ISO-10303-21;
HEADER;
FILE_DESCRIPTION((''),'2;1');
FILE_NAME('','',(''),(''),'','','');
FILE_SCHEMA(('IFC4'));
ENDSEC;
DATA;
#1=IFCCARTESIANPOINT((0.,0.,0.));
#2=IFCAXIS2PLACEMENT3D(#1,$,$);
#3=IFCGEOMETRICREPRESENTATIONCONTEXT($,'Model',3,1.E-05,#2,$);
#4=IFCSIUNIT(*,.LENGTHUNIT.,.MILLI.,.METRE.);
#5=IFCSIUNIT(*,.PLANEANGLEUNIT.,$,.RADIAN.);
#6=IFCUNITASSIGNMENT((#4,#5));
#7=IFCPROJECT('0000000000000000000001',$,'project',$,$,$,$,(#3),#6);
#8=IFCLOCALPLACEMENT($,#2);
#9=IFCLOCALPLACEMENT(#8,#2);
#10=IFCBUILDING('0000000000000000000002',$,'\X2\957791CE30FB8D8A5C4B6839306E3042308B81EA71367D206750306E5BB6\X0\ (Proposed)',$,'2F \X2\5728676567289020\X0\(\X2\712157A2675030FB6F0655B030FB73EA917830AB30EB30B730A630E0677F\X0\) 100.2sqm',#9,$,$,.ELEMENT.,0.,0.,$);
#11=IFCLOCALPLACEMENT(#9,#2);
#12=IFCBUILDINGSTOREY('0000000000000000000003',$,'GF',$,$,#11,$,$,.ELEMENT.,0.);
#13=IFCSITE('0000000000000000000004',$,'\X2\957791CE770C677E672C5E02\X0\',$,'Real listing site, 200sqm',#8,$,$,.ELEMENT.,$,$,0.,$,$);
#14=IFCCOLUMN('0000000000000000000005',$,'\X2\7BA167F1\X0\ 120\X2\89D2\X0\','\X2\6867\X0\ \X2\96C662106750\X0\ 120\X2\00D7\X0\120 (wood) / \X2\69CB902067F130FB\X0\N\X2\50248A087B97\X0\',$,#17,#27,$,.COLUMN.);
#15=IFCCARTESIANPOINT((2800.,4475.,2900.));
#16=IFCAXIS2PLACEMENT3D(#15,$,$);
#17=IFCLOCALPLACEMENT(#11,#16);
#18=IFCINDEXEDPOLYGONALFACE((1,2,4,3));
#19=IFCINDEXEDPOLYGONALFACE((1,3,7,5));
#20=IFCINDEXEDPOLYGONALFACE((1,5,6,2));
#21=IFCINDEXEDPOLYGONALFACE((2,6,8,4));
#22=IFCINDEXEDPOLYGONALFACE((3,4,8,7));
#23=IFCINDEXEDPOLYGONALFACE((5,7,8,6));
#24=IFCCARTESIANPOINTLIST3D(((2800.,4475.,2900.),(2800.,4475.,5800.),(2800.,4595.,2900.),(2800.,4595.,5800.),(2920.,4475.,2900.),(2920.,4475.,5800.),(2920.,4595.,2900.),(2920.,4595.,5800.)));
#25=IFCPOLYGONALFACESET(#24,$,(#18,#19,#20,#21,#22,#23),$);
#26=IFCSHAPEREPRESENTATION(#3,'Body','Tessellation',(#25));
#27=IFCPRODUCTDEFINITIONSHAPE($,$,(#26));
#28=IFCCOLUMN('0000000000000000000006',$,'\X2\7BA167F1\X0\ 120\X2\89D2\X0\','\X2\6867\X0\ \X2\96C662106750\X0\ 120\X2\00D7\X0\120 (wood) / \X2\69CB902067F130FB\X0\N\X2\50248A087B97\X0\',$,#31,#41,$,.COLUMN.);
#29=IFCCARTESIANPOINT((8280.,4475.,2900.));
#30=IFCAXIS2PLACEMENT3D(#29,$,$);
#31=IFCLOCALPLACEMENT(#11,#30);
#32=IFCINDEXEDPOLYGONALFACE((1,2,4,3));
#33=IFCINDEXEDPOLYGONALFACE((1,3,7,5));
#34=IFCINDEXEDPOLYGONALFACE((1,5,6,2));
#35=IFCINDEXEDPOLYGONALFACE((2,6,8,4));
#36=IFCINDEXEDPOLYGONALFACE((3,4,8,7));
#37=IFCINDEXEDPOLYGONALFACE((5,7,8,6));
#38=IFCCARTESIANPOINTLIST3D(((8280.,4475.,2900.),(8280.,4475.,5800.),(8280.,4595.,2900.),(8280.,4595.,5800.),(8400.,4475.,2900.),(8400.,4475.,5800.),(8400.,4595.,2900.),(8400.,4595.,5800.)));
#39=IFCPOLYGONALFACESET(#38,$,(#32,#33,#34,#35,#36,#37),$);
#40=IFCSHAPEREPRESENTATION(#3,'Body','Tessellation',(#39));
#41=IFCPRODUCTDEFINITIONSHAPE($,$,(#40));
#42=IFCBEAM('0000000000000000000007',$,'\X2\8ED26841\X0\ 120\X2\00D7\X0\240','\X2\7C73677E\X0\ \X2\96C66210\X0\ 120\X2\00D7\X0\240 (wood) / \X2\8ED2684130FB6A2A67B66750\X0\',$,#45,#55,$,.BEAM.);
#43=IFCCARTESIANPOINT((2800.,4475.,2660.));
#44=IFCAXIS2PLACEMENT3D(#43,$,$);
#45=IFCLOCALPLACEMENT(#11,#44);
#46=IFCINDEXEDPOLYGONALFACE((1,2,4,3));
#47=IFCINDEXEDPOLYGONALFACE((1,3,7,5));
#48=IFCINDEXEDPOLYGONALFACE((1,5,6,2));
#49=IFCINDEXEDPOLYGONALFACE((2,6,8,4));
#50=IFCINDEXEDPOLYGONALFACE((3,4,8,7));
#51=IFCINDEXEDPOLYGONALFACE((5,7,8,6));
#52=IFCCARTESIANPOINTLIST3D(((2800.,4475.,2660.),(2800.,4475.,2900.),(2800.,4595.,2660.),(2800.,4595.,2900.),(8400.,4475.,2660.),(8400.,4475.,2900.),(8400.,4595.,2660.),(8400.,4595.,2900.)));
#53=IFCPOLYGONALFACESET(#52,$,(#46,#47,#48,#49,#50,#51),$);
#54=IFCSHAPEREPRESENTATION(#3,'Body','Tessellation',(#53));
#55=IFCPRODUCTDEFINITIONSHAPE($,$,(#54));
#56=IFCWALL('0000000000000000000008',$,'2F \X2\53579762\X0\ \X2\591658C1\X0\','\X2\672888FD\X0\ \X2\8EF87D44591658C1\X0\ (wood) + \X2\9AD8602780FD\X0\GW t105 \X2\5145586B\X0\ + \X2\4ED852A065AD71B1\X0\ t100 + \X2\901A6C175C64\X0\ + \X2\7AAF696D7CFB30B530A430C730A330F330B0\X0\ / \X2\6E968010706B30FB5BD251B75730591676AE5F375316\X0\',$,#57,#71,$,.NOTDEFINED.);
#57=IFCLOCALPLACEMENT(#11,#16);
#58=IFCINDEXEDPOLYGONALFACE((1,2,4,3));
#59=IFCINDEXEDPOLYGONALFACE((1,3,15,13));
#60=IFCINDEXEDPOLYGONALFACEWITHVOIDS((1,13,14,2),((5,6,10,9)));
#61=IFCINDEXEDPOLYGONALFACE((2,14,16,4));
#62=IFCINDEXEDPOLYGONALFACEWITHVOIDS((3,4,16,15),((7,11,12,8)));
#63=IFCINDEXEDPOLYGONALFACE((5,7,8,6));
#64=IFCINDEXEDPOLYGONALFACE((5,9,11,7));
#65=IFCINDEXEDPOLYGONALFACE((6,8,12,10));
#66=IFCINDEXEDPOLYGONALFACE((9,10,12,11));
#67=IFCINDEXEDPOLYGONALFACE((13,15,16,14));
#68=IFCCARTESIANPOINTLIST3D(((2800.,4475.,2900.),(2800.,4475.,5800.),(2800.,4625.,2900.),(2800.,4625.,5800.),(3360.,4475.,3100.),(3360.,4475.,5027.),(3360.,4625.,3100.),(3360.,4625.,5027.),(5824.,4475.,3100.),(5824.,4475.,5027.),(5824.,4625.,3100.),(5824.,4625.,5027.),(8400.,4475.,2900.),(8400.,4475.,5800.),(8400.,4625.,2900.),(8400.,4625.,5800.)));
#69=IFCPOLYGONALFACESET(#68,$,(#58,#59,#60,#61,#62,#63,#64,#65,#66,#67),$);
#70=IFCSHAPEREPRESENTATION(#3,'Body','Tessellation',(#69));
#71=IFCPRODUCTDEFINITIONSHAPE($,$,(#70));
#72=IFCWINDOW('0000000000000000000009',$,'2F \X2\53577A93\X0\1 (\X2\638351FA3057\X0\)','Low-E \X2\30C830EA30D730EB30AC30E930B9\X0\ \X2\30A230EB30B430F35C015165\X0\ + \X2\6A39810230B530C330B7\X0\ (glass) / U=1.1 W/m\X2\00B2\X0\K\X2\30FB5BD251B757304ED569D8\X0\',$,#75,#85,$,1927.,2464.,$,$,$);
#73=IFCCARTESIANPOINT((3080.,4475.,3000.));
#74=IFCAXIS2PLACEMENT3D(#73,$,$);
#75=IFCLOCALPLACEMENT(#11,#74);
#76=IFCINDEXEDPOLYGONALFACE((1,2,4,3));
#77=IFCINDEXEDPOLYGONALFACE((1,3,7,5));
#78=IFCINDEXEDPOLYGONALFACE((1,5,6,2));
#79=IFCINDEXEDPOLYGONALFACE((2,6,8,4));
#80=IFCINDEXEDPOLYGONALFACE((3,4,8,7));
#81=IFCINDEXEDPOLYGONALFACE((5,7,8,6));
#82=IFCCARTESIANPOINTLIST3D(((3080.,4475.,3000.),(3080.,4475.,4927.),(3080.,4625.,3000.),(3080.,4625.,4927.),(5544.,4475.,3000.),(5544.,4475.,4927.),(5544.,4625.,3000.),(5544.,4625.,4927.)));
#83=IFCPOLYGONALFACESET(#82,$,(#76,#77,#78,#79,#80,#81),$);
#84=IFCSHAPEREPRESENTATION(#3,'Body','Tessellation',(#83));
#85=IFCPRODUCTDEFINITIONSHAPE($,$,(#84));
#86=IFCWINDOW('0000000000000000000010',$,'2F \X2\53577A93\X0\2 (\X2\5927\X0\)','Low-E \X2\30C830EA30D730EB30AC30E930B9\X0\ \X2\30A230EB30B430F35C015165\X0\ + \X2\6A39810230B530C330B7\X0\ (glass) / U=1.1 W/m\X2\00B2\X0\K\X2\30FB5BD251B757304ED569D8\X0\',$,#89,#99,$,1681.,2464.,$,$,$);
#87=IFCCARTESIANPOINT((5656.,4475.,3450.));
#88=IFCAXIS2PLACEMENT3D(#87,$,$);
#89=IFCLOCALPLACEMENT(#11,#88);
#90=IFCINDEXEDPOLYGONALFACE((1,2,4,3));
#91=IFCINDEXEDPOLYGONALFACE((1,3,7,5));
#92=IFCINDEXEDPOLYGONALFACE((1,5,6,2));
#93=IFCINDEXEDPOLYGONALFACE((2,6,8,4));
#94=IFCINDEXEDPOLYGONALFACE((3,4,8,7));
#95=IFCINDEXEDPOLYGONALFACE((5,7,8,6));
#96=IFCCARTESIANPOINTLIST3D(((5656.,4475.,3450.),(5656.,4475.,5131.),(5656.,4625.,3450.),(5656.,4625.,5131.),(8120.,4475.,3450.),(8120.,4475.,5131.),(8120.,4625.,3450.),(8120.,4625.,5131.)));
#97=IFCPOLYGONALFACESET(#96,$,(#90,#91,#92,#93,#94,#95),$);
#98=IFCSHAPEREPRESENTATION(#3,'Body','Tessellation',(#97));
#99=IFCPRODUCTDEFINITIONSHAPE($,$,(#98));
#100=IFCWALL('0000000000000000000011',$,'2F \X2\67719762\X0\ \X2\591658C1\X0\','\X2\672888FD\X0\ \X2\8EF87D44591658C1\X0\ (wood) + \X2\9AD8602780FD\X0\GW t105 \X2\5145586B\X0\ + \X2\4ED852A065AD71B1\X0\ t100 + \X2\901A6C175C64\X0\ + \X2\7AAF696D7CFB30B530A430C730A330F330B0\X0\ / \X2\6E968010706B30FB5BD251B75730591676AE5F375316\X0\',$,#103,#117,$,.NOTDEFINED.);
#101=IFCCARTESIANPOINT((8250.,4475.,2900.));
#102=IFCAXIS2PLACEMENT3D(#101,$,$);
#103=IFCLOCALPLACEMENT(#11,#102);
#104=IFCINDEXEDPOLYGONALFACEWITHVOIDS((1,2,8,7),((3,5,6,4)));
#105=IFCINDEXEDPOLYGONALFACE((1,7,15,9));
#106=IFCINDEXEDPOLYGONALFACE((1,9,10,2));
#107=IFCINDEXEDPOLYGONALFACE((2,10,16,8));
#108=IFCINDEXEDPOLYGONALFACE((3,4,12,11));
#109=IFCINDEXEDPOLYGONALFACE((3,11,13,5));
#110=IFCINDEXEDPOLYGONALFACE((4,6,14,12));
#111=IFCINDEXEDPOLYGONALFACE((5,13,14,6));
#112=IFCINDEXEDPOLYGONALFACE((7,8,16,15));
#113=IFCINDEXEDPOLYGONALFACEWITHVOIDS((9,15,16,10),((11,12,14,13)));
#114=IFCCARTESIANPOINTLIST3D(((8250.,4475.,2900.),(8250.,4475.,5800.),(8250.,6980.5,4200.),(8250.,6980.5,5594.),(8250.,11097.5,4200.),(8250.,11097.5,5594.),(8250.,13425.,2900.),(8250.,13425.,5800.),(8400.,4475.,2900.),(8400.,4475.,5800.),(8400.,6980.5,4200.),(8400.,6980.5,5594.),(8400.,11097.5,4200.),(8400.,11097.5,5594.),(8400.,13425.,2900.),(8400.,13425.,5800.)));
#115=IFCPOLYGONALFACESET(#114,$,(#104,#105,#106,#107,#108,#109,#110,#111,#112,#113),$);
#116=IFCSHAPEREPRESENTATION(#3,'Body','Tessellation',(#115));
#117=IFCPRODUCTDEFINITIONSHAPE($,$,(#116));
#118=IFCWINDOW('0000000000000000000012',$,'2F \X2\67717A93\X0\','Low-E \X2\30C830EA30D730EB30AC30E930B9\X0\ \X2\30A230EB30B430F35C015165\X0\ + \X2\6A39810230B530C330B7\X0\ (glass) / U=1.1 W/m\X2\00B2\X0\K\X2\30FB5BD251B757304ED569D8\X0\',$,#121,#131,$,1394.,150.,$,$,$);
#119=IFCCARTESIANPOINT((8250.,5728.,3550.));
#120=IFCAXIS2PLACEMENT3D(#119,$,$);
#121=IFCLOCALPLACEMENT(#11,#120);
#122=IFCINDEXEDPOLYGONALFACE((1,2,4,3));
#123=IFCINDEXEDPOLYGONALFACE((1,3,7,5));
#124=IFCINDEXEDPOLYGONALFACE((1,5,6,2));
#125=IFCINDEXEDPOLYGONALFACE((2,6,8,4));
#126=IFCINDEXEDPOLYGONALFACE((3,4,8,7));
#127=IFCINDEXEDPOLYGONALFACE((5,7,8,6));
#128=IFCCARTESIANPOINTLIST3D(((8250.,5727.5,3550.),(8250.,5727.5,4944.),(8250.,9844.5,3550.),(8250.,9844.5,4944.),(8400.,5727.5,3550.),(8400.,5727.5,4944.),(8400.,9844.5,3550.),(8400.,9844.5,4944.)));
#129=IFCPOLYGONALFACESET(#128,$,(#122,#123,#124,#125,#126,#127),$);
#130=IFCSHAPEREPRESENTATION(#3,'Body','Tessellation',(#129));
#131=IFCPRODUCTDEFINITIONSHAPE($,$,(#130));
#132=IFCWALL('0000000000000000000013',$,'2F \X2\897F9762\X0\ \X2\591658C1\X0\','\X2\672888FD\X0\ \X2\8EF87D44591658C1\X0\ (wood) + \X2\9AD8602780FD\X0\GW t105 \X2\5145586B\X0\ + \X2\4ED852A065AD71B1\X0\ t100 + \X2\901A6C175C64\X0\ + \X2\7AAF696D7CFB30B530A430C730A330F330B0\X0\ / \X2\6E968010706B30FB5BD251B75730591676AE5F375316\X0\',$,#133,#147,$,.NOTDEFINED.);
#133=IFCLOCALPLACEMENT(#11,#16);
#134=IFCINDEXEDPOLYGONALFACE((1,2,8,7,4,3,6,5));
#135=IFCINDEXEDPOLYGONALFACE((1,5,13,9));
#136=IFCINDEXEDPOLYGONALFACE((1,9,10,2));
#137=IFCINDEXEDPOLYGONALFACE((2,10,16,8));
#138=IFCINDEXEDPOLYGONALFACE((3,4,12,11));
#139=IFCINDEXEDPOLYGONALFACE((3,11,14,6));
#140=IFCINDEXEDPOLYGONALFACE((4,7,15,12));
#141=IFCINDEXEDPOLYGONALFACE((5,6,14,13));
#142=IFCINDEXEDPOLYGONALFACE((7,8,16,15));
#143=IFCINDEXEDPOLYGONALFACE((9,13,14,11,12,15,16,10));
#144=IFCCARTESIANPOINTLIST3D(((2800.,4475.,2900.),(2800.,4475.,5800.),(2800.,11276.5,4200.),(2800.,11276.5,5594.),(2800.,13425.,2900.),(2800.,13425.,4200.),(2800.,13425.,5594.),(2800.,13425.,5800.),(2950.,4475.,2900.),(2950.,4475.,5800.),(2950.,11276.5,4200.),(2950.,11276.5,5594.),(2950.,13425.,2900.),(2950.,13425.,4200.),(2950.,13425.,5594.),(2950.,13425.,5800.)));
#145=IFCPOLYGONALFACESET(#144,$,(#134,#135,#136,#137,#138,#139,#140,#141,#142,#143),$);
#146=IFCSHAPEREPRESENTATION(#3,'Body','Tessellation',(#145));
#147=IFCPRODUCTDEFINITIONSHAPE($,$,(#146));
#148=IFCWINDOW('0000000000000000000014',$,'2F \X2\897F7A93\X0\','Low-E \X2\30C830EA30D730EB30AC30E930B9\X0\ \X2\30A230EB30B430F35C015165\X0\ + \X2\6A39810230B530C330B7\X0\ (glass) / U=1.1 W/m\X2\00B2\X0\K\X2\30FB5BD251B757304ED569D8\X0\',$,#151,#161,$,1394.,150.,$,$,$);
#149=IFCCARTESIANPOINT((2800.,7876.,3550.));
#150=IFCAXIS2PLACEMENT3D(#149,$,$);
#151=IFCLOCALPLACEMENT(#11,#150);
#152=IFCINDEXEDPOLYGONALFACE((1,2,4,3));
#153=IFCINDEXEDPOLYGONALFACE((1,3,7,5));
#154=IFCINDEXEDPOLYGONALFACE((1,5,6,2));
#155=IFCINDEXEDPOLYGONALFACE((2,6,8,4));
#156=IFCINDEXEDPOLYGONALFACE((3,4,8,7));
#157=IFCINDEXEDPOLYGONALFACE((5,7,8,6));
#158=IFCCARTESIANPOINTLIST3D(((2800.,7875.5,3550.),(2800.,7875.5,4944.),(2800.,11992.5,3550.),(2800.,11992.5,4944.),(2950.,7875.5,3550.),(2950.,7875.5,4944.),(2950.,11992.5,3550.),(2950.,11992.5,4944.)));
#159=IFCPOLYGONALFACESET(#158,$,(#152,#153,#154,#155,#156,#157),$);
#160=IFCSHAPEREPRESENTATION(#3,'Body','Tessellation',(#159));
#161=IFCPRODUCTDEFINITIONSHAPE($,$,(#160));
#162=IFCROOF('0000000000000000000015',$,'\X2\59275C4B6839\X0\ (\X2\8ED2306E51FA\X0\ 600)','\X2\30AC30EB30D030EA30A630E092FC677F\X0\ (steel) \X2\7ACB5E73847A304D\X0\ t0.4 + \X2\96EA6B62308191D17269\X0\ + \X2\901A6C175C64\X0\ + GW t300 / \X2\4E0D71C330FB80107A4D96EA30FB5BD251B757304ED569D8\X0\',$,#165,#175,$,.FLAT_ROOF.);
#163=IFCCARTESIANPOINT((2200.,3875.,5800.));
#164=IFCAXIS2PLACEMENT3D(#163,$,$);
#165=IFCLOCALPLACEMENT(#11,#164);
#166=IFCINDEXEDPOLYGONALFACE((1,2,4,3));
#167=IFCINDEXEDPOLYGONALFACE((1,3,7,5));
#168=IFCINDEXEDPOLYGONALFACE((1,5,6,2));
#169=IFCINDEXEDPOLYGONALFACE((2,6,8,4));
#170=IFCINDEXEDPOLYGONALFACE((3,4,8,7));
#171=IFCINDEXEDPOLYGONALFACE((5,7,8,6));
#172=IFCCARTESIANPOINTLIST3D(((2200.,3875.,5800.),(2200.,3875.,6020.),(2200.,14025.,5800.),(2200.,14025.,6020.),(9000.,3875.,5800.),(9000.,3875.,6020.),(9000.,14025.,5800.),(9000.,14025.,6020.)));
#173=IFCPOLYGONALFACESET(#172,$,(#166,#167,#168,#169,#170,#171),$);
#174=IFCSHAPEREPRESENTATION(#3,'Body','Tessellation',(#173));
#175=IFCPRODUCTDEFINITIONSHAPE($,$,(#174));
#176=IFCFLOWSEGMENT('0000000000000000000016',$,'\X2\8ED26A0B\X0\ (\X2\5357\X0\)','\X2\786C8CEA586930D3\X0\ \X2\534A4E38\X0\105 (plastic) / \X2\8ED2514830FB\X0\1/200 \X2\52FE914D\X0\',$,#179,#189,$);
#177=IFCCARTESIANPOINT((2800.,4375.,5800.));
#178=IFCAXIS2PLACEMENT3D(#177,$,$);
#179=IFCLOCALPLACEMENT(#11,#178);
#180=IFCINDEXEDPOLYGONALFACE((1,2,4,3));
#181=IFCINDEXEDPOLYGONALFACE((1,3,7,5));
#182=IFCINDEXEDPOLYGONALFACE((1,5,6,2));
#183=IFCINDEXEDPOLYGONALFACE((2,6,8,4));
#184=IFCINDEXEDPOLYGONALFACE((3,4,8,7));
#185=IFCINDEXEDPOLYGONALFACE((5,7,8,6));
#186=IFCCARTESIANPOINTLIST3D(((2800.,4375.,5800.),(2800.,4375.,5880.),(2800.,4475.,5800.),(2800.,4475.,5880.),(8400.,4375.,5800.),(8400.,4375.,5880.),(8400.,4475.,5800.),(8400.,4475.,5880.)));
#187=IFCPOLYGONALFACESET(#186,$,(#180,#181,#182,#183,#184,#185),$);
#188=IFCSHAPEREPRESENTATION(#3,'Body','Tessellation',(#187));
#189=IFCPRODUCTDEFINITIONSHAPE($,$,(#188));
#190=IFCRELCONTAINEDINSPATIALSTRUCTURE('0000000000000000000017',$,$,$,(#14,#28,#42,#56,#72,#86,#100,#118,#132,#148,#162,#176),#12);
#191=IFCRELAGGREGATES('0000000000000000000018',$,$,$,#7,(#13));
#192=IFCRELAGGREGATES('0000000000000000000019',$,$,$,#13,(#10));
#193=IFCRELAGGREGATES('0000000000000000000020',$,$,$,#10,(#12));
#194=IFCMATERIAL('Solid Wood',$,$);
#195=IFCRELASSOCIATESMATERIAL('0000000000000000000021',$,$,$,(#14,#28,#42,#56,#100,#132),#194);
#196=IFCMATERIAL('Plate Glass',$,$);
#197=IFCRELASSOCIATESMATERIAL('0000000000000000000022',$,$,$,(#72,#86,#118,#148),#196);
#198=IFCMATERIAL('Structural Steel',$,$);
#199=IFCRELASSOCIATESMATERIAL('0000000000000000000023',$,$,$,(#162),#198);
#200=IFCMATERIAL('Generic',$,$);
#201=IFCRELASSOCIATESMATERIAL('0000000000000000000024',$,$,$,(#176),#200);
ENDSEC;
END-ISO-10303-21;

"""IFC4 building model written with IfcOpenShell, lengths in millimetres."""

from ifc_helpers import new_model, si_unit, frame, frame_2d, origin, place, context, project, spatial, rectangle, extrude, material, element, fill, save


model = new_model("IFC4")

# Units and contexts
model_context = context("Model", 3, precision=1e-05, world=origin())
ifc_project = project(units=[si_unit("LENGTHUNIT", "METRE", prefix="MILLI"), si_unit("PLANEANGLEUNIT", "RADIAN")], contexts=[model_context])

# Site, building, storey
site_placement = place(None, origin())
site = spatial("IfcSite", under=ifc_project, at=site_placement, Name="長野県松本市", ObjectType="Real listing site, 200sqm", CompositionType="ELEMENT", RefElevation=0.0)
building_placement = place(site_placement, origin())
building = spatial("IfcBuilding", under=site, at=building_placement, Name="長野・越屋根のある自然素材の家 (Proposed)", ObjectType="2F 在来木造(無垢材・漆喰・珪酸カルシウム板) 100.2sqm", CompositionType="ELEMENT", ElevationOfRefHeight=0.0, ElevationOfTerrain=0.0)
storey_placement = place(building_placement, origin())
storey = spatial("IfcBuildingStorey", under=building, at=storey_placement, Name="GF", CompositionType="ELEMENT", Elevation=0.0)

# Columns
ifc_material_1 = material(Name="Solid Wood")
column_1_placement = place(storey_placement, frame((2800.0, 4475.0, 2900.0)))
element("IfcColumn", 1, at=column_1_placement, inside=storey, material=ifc_material_1, Name="管柱 120角", Description="桧 集成材 120×120 (wood) / 構造柱・N値計算", PredefinedType="COLUMN", context=model_context, shape_type="SweptSolid", body=[
    extrude(rectangle(XDim=120.0, YDim=120.0, at=frame_2d((60.0, 60.0))), frame((2800.0, 4475.0, 2900.0)), (0.0, 0.0, 1.0), 2900.0),
])
column_2_placement = place(storey_placement, frame((8280.0, 4475.0, 2900.0)))
element("IfcColumn", 2, at=column_2_placement, inside=storey, material=ifc_material_1, Name="管柱 120角", Description="桧 集成材 120×120 (wood) / 構造柱・N値計算", PredefinedType="COLUMN", context=model_context, shape_type="SweptSolid", body=[
    extrude(rectangle(XDim=120.0, YDim=120.0, at=frame_2d((60.0, 60.0))), frame((8280.0, 4475.0, 2900.0)), (0.0, 0.0, 1.0), 2900.0),
])

# Beam
beam_1_placement = place(storey_placement, frame((2800.0, 4475.0, 2660.0)))
element("IfcBeam", 3, at=beam_1_placement, inside=storey, material=ifc_material_1, Name="軒桁 120×240", Description="米松 集成 120×240 (wood) / 軒桁・横架材", PredefinedType="BEAM", context=model_context, shape_type="SweptSolid", body=[
    extrude(rectangle(XDim=5600.0, YDim=120.0, at=frame_2d((2800.0, 60.0))), frame((2800.0, 4475.0, 2660.0)), (0.0, 0.0, 1.0), 240.0),
])

# Wall, openings, windows
wall_1_placement = place(storey_placement, frame((2800.0, 4475.0, 2900.0)))
wall_1 = element("IfcWall", 4, at=wall_1_placement, inside=storey, material=ifc_material_1, Name="2F 南面 外壁", Description="木製 軸組外壁 (wood) + 高性能GW t105 充填 + 付加断熱 t100 + 通気層 + 窯業系サイディング / 準耐火・寒冷地外皮強化", PredefinedType="NOTDEFINED", context=model_context, shape_type="SweptSolid", body=[
    extrude(rectangle(XDim=5600.0, YDim=150.0, at=frame_2d((2800.0, 75.0))), frame((2800.0, 4475.0, 2900.0)), (0.0, 0.0, 1.0), 2900.0),
])
opening_1_placement = place(storey_placement, frame((3080.0, 4475.0, 3000.0)))
opening_1 = element("IfcOpeningElement", 5, at=opening_1_placement, cuts=wall_1, PredefinedType="NOTDEFINED", context=model_context, shape_type="SweptSolid", body=[
    extrude(rectangle(XDim=2464.0, YDim=150.0, at=frame_2d((1232.0, 75.0))), frame((3080.0, 4475.0, 3000.0)), (0.0, 0.0, 1.0), 1927.0),
])
opening_2_placement = place(storey_placement, frame((5656.0, 4475.0, 3450.0)))
opening_2 = element("IfcOpeningElement", 6, at=opening_2_placement, cuts=wall_1, PredefinedType="NOTDEFINED", context=model_context, shape_type="SweptSolid", body=[
    extrude(rectangle(XDim=2464.0, YDim=150.0, at=frame_2d((1232.0, 75.0))), frame((5656.0, 4475.0, 3450.0)), (0.0, 0.0, 1.0), 1681.0),
])
ifc_material_2 = material(Name="Plate Glass")
window_1_placement = place(storey_placement, frame((3080.0, 4475.0, 3000.0)))
window_1 = element("IfcWindow", 7, at=window_1_placement, inside=storey, material=ifc_material_2, Name="2F 南窓1 (掃出し)", Description="Low-E トリプルガラス アルゴン封入 + 樹脂サッシ (glass) / U=1.1 W/m²K・寒冷地仕様", OverallHeight=1927.0, OverallWidth=2464.0, context=model_context, shape_type="SweptSolid", body=[
    extrude(rectangle(XDim=2464.0, YDim=150.0, at=frame_2d((1232.0, 75.0))), frame((3080.0, 4475.0, 3000.0)), (0.0, 0.0, 1.0), 1927.0),
])
fill(opening_1, window_1)
window_2_placement = place(storey_placement, frame((5656.0, 4475.0, 3450.0)))
window_2 = element("IfcWindow", 8, at=window_2_placement, inside=storey, material=ifc_material_2, Name="2F 南窓2 (大)", Description="Low-E トリプルガラス アルゴン封入 + 樹脂サッシ (glass) / U=1.1 W/m²K・寒冷地仕様", OverallHeight=1681.0, OverallWidth=2464.0, context=model_context, shape_type="SweptSolid", body=[
    extrude(rectangle(XDim=2464.0, YDim=150.0, at=frame_2d((1232.0, 75.0))), frame((5656.0, 4475.0, 3450.0)), (0.0, 0.0, 1.0), 1681.0),
])
fill(opening_2, window_2)

# Walls, openings, windows
wall_2_placement = place(storey_placement, frame((8250.0, 4475.0, 2900.0)))
wall_2 = element("IfcWall", 9, at=wall_2_placement, inside=storey, material=ifc_material_1, Name="2F 東面 外壁", Description="木製 軸組外壁 (wood) + 高性能GW t105 充填 + 付加断熱 t100 + 通気層 + 窯業系サイディング / 準耐火・寒冷地外皮強化", PredefinedType="NOTDEFINED", context=model_context, shape_type="SweptSolid", body=[
    extrude(rectangle(XDim=150.0, YDim=8950.0, at=frame_2d((75.0, 4475.0))), frame((8250.0, 4475.0, 2900.0)), (0.0, 0.0, 1.0), 2900.0),
])
opening_3_placement = place(storey_placement, frame((8250.0, 5728.0, 3550.0)))
opening_3 = element("IfcOpeningElement", 10, at=opening_3_placement, cuts=wall_2, PredefinedType="NOTDEFINED", context=model_context, shape_type="SweptSolid", body=[
    extrude(rectangle(XDim=150.0, YDim=4117.0, at=frame_2d((75.0, 2058.0))), frame((8250.0, 5728.0, 3550.0)), (0.0, 0.0, 1.0), 1394.0),
])
window_3_placement = place(storey_placement, frame((8250.0, 5728.0, 3550.0)))
window_3 = element("IfcWindow", 11, at=window_3_placement, inside=storey, material=ifc_material_2, Name="2F 東窓", Description="Low-E トリプルガラス アルゴン封入 + 樹脂サッシ (glass) / U=1.1 W/m²K・寒冷地仕様", OverallHeight=1394.0, OverallWidth=150.0, context=model_context, shape_type="SweptSolid", body=[
    extrude(rectangle(XDim=150.0, YDim=4117.0, at=frame_2d((75.0, 2058.0))), frame((8250.0, 5728.0, 3550.0)), (0.0, 0.0, 1.0), 1394.0),
])
fill(opening_3, window_3)
wall_3_placement = place(storey_placement, frame((2800.0, 4475.0, 2900.0)))
wall_3 = element("IfcWall", 12, at=wall_3_placement, inside=storey, material=ifc_material_1, Name="2F 西面 外壁", Description="木製 軸組外壁 (wood) + 高性能GW t105 充填 + 付加断熱 t100 + 通気層 + 窯業系サイディング / 準耐火・寒冷地外皮強化", PredefinedType="NOTDEFINED", context=model_context, shape_type="SweptSolid", body=[
    extrude(rectangle(XDim=150.0, YDim=8950.0, at=frame_2d((75.0, 4475.0))), frame((2800.0, 4475.0, 2900.0)), (0.0, 0.0, 1.0), 2900.0),
])
opening_4_placement = place(storey_placement, frame((2800.0, 7876.0, 3550.0)))
opening_4 = element("IfcOpeningElement", 13, at=opening_4_placement, cuts=wall_3, PredefinedType="NOTDEFINED", context=model_context, shape_type="SweptSolid", body=[
    extrude(rectangle(XDim=150.0, YDim=4117.0, at=frame_2d((75.0, 2058.0))), frame((2800.0, 7876.0, 3550.0)), (0.0, 0.0, 1.0), 1394.0),
])
window_4_placement = place(storey_placement, frame((2800.0, 7876.0, 3550.0)))
window_4 = element("IfcWindow", 14, at=window_4_placement, inside=storey, material=ifc_material_2, Name="2F 西窓", Description="Low-E トリプルガラス アルゴン封入 + 樹脂サッシ (glass) / U=1.1 W/m²K・寒冷地仕様", OverallHeight=1394.0, OverallWidth=150.0, context=model_context, shape_type="SweptSolid", body=[
    extrude(rectangle(XDim=150.0, YDim=4117.0, at=frame_2d((75.0, 2058.0))), frame((2800.0, 7876.0, 3550.0)), (0.0, 0.0, 1.0), 1394.0),
])
fill(opening_4, window_4)

# Roof
ifc_material_3 = material(Name="Structural Steel")
roof_placement = place(storey_placement, frame((2200.0, 3875.0, 5800.0)))
element("IfcRoof", 15, at=roof_placement, inside=storey, material=ifc_material_3, Name="大屋根 (軒の出 600)", Description="ガルバリウム鋼板 (steel) 立平葺き t0.4 + 雪止め金物 + 通気層 + GW t300 / 不燃・耐積雪・寒冷地仕様", PredefinedType="FLAT_ROOF", context=model_context, shape_type="SweptSolid", body=[
    extrude(rectangle(XDim=6800.0, YDim=10150.0, at=frame_2d((3400.0, 5075.0))), frame((2200.0, 3875.0, 5800.0)), (0.0, 0.0, 1.0), 220.0),
])

# Flow segment
ifc_material_4 = material(Name="Generic")
flow_segment_placement = place(storey_placement, frame((2800.0, 4375.0, 5800.0)))
element("IfcFlowSegment", 16, at=flow_segment_placement, inside=storey, material=ifc_material_4, Name="軒樋 (南)", Description="硬質塩ビ 半丸105 (plastic) / 軒先・1/200 勾配", context=model_context, shape_type="SweptSolid", body=[
    extrude(rectangle(XDim=5600.0, YDim=100.0, at=frame_2d((2800.0, 50.0))), frame((2800.0, 4375.0, 5800.0)), (0.0, 0.0, 1.0), 80.0),
])

save(model, "model.ifc")
